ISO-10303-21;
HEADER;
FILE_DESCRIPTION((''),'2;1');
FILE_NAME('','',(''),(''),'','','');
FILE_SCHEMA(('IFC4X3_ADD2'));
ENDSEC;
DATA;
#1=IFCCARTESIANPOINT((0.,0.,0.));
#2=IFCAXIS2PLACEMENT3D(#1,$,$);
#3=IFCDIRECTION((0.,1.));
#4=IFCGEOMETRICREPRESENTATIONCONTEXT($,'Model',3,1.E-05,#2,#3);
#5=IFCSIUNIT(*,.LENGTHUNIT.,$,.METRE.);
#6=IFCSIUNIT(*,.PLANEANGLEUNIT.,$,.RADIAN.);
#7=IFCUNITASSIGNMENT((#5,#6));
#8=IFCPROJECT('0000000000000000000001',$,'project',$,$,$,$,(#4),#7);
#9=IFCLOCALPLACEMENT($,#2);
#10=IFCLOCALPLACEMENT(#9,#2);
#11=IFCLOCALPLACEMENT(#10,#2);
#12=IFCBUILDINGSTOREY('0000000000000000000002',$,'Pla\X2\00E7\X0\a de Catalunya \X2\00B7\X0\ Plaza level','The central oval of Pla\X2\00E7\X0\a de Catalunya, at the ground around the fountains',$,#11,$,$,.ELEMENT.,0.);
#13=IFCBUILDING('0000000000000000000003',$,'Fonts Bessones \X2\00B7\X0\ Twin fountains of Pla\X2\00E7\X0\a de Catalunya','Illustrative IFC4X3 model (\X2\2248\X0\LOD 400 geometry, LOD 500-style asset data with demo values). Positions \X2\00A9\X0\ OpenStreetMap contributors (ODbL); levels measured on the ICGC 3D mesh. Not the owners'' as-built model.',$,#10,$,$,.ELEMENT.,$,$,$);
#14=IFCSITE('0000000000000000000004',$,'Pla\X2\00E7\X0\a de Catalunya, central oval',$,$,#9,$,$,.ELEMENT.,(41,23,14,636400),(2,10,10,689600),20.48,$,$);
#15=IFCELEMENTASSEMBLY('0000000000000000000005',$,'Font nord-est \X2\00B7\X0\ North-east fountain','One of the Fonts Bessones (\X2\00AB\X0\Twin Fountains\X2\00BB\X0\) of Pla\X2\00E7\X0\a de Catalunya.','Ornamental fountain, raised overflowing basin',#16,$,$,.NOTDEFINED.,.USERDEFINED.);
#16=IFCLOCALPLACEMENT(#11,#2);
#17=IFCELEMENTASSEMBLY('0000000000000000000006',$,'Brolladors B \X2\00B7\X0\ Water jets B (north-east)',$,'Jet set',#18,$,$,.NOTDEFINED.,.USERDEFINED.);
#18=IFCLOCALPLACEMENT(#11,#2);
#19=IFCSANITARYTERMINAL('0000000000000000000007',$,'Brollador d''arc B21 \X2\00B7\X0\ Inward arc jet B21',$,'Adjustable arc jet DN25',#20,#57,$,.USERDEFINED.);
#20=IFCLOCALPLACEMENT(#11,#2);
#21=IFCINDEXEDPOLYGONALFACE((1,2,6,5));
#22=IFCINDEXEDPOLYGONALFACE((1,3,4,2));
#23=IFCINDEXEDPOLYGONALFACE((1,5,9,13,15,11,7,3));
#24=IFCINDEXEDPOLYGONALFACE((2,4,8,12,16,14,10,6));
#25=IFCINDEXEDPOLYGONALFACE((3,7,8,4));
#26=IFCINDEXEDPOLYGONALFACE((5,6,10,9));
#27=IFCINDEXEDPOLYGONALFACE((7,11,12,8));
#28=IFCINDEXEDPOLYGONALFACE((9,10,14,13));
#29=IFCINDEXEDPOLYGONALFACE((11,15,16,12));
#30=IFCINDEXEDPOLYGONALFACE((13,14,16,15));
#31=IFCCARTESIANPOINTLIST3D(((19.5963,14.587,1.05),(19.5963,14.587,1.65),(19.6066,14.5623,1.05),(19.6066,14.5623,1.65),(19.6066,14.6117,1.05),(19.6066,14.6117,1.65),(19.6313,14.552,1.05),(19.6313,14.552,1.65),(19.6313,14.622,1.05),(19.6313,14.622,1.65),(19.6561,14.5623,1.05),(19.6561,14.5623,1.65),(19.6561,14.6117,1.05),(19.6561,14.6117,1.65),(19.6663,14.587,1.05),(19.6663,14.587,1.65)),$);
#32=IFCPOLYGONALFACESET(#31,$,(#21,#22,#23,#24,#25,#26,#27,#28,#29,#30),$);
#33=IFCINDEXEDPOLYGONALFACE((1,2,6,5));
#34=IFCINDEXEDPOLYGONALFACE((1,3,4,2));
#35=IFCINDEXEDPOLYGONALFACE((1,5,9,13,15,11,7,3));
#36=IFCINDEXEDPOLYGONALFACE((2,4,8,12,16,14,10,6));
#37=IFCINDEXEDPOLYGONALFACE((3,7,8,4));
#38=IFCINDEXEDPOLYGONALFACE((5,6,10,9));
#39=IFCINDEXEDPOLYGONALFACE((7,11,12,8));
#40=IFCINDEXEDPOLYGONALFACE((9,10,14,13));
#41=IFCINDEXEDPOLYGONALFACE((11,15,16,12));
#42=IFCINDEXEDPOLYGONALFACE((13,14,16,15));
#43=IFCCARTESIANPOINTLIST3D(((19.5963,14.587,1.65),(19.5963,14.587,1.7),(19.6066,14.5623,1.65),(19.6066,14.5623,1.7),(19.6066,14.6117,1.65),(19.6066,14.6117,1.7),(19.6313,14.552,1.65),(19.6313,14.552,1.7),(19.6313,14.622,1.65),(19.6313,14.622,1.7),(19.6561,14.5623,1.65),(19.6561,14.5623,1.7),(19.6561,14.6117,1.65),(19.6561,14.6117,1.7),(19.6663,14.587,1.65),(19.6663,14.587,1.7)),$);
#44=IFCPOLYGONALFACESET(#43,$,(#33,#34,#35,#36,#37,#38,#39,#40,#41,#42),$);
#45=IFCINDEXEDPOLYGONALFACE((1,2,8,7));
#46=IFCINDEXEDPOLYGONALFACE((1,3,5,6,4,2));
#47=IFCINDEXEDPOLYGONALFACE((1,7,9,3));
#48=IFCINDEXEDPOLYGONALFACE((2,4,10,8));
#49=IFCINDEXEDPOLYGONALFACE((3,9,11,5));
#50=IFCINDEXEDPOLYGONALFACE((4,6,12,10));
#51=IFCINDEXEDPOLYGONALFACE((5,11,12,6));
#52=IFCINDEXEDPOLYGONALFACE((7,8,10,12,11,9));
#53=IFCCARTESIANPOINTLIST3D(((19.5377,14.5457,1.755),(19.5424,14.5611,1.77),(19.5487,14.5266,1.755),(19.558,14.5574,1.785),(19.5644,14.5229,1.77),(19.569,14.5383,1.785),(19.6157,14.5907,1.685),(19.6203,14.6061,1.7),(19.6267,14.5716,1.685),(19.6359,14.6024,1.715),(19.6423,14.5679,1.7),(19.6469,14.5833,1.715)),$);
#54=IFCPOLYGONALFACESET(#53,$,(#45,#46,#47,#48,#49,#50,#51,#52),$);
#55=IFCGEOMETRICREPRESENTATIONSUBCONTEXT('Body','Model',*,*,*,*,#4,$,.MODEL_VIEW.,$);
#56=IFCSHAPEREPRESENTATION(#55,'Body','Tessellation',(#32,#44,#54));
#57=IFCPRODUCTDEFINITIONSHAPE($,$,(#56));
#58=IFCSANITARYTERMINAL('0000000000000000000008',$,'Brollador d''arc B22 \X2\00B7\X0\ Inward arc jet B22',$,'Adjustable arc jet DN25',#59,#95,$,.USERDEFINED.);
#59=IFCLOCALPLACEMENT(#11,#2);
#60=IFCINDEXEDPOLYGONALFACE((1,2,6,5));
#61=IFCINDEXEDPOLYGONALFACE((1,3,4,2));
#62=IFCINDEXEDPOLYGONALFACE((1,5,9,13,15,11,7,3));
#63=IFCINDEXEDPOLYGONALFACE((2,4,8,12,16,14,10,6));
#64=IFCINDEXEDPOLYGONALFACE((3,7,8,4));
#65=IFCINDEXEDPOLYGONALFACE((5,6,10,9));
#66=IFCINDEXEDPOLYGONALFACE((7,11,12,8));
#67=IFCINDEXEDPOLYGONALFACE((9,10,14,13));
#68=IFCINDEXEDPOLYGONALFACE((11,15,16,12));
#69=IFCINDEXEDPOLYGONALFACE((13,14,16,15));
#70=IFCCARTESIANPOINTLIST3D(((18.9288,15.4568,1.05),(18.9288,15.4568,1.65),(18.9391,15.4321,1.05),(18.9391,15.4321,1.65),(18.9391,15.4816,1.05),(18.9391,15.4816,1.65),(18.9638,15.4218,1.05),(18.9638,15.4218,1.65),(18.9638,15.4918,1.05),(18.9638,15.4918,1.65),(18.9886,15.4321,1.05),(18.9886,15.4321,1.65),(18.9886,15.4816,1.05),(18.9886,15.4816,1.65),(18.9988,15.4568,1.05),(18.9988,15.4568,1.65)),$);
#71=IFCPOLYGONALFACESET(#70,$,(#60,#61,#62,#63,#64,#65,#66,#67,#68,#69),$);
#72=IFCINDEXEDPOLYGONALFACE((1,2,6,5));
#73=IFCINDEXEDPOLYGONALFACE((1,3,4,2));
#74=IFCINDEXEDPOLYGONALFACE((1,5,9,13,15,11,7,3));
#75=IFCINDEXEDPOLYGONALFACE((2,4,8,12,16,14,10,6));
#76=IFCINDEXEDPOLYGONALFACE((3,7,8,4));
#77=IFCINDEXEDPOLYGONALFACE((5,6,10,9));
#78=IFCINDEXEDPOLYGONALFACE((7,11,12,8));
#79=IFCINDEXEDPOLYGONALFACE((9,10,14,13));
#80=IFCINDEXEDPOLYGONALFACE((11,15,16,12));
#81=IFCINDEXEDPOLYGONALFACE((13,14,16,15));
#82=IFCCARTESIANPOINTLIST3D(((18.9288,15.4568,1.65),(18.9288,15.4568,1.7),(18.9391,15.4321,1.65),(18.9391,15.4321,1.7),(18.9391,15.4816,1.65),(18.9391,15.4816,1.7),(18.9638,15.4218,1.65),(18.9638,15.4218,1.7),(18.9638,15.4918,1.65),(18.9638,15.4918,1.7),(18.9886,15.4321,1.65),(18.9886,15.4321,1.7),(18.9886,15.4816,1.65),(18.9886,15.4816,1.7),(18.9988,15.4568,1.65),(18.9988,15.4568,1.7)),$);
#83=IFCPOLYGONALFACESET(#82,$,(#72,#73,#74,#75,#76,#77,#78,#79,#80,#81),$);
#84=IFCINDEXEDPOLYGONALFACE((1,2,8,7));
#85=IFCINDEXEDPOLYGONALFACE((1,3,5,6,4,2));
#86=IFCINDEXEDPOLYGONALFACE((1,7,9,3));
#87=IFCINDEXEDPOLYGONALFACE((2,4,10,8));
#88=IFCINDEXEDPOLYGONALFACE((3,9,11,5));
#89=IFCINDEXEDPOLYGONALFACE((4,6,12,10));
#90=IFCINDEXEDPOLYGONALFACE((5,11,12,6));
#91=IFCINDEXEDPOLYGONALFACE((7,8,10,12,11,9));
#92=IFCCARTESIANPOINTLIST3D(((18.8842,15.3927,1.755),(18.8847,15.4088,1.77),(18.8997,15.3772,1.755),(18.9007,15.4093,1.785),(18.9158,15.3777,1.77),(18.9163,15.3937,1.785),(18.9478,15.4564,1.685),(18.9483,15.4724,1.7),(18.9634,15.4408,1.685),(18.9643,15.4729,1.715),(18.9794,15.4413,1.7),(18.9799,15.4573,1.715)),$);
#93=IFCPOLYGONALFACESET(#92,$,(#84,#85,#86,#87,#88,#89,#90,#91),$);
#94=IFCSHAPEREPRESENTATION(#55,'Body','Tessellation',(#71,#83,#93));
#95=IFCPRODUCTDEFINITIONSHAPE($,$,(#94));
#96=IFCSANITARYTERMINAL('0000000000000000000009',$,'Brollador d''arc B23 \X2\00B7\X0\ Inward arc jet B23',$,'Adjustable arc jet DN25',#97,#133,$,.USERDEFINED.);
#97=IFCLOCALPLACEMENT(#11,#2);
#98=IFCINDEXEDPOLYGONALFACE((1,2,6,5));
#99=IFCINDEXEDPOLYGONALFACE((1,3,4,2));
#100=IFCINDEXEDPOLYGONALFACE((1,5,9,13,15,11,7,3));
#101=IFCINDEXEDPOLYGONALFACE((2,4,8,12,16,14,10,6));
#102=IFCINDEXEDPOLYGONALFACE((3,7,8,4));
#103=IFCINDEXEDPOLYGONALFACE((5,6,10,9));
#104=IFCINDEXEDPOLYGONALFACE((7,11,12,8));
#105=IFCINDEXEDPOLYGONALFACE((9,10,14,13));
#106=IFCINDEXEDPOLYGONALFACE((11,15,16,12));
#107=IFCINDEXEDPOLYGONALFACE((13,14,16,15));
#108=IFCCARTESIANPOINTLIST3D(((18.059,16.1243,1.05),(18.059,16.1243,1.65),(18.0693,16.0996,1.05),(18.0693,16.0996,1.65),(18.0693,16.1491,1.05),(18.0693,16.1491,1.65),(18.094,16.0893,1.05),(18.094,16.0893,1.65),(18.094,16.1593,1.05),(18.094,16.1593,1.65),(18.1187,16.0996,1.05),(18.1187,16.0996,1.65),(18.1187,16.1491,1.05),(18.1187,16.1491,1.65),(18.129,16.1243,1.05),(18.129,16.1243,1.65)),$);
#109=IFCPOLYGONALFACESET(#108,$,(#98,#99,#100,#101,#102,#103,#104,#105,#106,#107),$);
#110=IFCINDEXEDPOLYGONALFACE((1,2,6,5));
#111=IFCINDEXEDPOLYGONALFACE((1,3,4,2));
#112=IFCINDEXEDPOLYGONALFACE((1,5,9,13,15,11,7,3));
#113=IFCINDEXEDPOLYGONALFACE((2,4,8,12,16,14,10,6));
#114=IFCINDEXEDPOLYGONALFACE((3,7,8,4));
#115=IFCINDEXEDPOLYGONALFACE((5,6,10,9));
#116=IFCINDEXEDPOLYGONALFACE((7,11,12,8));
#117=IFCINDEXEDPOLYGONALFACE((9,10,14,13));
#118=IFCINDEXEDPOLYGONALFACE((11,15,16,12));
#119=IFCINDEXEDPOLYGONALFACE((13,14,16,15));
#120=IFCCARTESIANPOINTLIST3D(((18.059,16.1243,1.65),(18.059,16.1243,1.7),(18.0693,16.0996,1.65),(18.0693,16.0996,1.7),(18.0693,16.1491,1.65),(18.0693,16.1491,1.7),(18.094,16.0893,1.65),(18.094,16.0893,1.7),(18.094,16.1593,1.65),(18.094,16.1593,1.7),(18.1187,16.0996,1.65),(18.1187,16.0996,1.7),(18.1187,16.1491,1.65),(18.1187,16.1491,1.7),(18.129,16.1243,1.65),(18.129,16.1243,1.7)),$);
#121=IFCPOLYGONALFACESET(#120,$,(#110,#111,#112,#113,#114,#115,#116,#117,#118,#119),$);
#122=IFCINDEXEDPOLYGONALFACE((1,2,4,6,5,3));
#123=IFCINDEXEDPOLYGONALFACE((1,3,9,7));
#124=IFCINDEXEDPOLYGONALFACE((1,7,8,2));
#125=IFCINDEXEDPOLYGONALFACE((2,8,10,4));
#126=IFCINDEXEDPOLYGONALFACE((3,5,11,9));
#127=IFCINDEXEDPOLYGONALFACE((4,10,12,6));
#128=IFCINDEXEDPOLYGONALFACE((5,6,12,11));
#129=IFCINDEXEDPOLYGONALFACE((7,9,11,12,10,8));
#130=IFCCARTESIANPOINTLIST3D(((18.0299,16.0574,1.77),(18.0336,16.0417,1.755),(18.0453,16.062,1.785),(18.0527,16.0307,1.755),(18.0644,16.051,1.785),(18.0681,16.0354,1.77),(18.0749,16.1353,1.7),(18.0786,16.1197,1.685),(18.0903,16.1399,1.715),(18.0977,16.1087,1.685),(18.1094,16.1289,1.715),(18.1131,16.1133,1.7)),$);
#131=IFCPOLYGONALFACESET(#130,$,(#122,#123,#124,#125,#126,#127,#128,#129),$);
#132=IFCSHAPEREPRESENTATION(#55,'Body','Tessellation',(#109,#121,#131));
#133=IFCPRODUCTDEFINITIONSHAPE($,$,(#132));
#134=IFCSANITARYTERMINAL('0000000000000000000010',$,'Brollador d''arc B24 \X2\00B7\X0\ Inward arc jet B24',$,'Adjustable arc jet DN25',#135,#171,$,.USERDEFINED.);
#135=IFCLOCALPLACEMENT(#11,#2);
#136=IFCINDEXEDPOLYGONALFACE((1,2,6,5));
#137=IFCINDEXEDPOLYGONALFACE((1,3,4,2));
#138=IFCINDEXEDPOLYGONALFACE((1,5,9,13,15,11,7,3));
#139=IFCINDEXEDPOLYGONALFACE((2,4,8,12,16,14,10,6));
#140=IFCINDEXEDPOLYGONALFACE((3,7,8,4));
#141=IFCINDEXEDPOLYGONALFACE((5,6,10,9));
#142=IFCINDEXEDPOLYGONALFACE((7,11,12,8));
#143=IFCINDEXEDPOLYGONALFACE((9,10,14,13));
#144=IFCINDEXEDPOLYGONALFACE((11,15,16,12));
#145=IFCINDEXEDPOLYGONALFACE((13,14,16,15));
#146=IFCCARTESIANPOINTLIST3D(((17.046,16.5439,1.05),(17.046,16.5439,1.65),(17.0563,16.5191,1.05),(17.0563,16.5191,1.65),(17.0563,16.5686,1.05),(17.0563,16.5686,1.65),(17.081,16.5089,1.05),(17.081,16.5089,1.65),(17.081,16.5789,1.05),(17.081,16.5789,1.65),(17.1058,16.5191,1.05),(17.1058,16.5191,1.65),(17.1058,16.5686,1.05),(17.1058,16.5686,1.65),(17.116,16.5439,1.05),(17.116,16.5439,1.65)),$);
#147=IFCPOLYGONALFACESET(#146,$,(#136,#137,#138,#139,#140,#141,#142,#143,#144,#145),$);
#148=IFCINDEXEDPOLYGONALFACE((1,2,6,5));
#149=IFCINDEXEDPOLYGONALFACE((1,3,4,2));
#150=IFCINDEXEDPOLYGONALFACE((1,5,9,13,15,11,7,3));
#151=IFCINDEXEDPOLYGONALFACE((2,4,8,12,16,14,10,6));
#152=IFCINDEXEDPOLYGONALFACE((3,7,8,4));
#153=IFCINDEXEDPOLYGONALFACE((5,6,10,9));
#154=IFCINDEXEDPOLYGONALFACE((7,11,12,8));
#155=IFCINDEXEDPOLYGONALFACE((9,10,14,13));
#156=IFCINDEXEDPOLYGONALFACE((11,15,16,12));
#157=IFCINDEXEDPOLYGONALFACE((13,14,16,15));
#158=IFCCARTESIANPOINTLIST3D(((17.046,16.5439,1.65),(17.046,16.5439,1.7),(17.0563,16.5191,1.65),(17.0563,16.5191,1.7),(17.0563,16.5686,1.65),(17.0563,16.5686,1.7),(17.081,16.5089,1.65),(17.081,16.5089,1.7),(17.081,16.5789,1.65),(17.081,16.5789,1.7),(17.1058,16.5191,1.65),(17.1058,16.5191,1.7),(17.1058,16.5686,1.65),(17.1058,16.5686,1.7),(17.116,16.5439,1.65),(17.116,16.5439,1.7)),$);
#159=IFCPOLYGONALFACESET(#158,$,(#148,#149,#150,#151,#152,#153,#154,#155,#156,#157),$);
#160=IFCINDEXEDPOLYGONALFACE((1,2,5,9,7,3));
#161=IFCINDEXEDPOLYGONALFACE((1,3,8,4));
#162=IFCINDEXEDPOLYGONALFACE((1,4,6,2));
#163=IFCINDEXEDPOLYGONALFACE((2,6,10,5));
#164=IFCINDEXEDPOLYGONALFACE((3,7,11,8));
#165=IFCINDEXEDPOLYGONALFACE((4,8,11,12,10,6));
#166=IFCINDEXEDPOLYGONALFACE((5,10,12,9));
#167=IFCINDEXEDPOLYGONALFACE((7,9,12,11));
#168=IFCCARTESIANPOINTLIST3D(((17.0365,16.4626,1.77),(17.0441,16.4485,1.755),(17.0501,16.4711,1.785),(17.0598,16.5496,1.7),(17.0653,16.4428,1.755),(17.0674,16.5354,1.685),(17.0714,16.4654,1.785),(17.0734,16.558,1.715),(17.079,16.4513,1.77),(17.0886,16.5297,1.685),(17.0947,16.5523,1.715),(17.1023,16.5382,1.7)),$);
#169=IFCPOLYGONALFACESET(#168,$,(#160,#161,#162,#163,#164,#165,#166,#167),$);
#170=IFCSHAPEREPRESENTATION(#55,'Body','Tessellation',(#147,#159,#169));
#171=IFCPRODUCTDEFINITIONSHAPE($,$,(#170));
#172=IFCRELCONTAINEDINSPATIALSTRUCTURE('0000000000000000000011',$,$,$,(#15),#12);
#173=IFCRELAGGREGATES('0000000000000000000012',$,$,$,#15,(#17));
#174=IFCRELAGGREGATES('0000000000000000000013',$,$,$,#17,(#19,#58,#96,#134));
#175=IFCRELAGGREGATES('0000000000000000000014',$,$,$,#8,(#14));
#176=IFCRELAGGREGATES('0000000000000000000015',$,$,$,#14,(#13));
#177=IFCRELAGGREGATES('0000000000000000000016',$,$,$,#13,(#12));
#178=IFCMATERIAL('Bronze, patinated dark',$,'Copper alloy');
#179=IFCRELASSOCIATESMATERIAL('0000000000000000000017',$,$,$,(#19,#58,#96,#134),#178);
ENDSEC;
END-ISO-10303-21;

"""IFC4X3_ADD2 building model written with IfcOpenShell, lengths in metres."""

from ifc_helpers import new_model, si_unit, direction, frame, origin, place, context, subcontext, project, spatial, polyline, outline, extrude, material, element, aggregate, save


model = new_model("IFC4X3_ADD2")

# Units and contexts
model_context = context("Model", 3, precision=1e-05, world=origin(), true_north=direction((0.0, 1.0)))
body_context = subcontext(model_context, "Body", "Model", "MODEL_VIEW")
ifc_project = project(units=[si_unit("LENGTHUNIT", "METRE"), si_unit("PLANEANGLEUNIT", "RADIAN")], contexts=[model_context])

# Site, building, storey
site_placement = place(None, origin())
site = spatial("IfcSite", under=ifc_project, at=site_placement, Name="Plaça de Catalunya, central oval", CompositionType="ELEMENT", RefLatitude=(41, 23, 14, 636400), RefLongitude=(2, 10, 10, 689600), RefElevation=20.48)
building_placement = place(site_placement, origin())
building = spatial("IfcBuilding", under=site, at=building_placement, Name="Fonts Bessones · Twin fountains of Plaça de Catalunya", Description="Illustrative IFC4X3 model (≈LOD 400 geometry, LOD 500-style asset data with demo values). Positions © OpenStreetMap contributors (ODbL); levels measured on the ICGC 3D mesh. Not the owners' as-built model.", CompositionType="ELEMENT")
storey_placement = place(building_placement, origin())
storey = spatial("IfcBuildingStorey", under=building, at=storey_placement, Name="Plaça de Catalunya · Plaza level", Description="The central oval of Plaça de Catalunya, at the ground around the fountains", CompositionType="ELEMENT", Elevation=0.0)

# Element assemblies, sanitary terminals
assembly_1_placement = place(building_placement, origin())
assembly_1 = element("IfcElementAssembly", 1, at=assembly_1_placement, inside=storey, Name="Font nord-est · North-east fountain", Description="One of the Fonts Bessones («Twin Fountains») of Plaça de Catalunya.", ObjectType="Ornamental fountain, raised overflowing basin", AssemblyPlace="NOTDEFINED", PredefinedType="USERDEFINED")
assembly_2_placement = place(building_placement, origin())
assembly_2 = element("IfcElementAssembly", 2, at=assembly_2_placement, Name="Brolladors B · Water jets B (north-east)", ObjectType="Jet set", AssemblyPlace="NOTDEFINED", PredefinedType="USERDEFINED")
aggregate(assembly_1, [assembly_2])
ifc_material_1 = material(Name="Bronze, patinated dark", Category="Copper alloy")
sanitary_terminal_1_placement = place(building_placement, origin())
sanitary_terminal_1 = element("IfcSanitaryTerminal", 3, at=sanitary_terminal_1_placement, material=ifc_material_1, Name="Brollador d'arc B21 · Inward arc jet B21", ObjectType="Adjustable arc jet DN25", PredefinedType="USERDEFINED", context=body_context, shape_type="SweptSolid", body=[
    extrude(outline(polyline([(19.6663, 14.587), (19.6561, 14.6117), (19.6313, 14.622), (19.6066, 14.6117), (19.5963, 14.587), (19.6066, 14.5623), (19.6313, 14.552), (19.6561, 14.5623), (19.6663, 14.587)])), frame((0.0, 0.0, 1.05)), (0.0, 0.0, 1.0), 0.6),
    extrude(outline(polyline([(19.6663, 14.587), (19.6561, 14.6117), (19.6313, 14.622), (19.6066, 14.6117), (19.5963, 14.587), (19.6066, 14.5623), (19.6313, 14.552), (19.6561, 14.5623), (19.6663, 14.587)])), frame((0.0, 0.0, 1.65)), (0.0, 0.0, 1.0), 0.05),
    extrude(outline(polyline([(0.022, 0.0), (0.011, 0.0191), (-0.011, 0.0191), (-0.022, 0.0), (-0.011, -0.0191), (0.011, -0.0191), (0.022, 0.0)])), frame((19.6313, 14.587, 1.7), z_axis=(-0.683599, -0.394676, 0.613941), x_axis=(-0.5, 0.866025, 0.0)), (0.0, 0.0, 1.0), 0.114),
])
sanitary_terminal_2_placement = place(building_placement, origin())
sanitary_terminal_2 = element("IfcSanitaryTerminal", 4, at=sanitary_terminal_2_placement, material=ifc_material_1, Name="Brollador d'arc B22 · Inward arc jet B22", ObjectType="Adjustable arc jet DN25", PredefinedType="USERDEFINED", context=body_context, shape_type="SweptSolid", body=[
    extrude(outline(polyline([(18.9988, 15.4568), (18.9886, 15.4816), (18.9638, 15.4918), (18.9391, 15.4816), (18.9288, 15.4568), (18.9391, 15.4321), (18.9638, 15.4218), (18.9886, 15.4321), (18.9988, 15.4568)])), frame((0.0, 0.0, 1.05)), (0.0, 0.0, 1.0), 0.6),
    extrude(outline(polyline([(18.9988, 15.4568), (18.9886, 15.4816), (18.9638, 15.4918), (18.9391, 15.4816), (18.9288, 15.4568), (18.9391, 15.4321), (18.9638, 15.4218), (18.9886, 15.4321), (18.9988, 15.4568)])), frame((0.0, 0.0, 1.65)), (0.0, 0.0, 1.0), 0.05),
    extrude(outline(polyline([(0.022, 0.0), (0.011, 0.0191), (-0.011, 0.0191), (-0.022, 0.0), (-0.011, -0.0191), (0.011, -0.0191), (0.022, 0.0)])), frame((18.9638, 15.4568, 1.7), z_axis=(-0.558156, -0.558156, 0.613941), x_axis=(-0.707107, 0.707107, 0.0)), (0.0, 0.0, 1.0), 0.114),
])
sanitary_terminal_3_placement = place(building_placement, origin())
sanitary_terminal_3 = element("IfcSanitaryTerminal", 5, at=sanitary_terminal_3_placement, material=ifc_material_1, Name="Brollador d'arc B23 · Inward arc jet B23", ObjectType="Adjustable arc jet DN25", PredefinedType="USERDEFINED", context=body_context, shape_type="SweptSolid", body=[
    extrude(outline(polyline([(18.129, 16.1243), (18.1187, 16.1491), (18.094, 16.1593), (18.0693, 16.1491), (18.059, 16.1243), (18.0693, 16.0996), (18.094, 16.0893), (18.1187, 16.0996), (18.129, 16.1243)])), frame((0.0, 0.0, 1.05)), (0.0, 0.0, 1.0), 0.6),
    extrude(outline(polyline([(18.129, 16.1243), (18.1187, 16.1491), (18.094, 16.1593), (18.0693, 16.1491), (18.059, 16.1243), (18.0693, 16.0996), (18.094, 16.0893), (18.1187, 16.0996), (18.129, 16.1243)])), frame((0.0, 0.0, 1.65)), (0.0, 0.0, 1.0), 0.05),
    extrude(outline(polyline([(0.022, 0.0), (0.011, 0.0191), (-0.011, 0.0191), (-0.022, 0.0), (-0.011, -0.0191), (0.011, -0.0191), (0.022, 0.0)])), frame((18.094, 16.1243, 1.7), z_axis=(-0.394676, -0.683599, 0.613941), x_axis=(-0.866025, 0.5, 0.0)), (0.0, 0.0, 1.0), 0.114),
])
sanitary_terminal_4_placement = place(building_placement, origin())
sanitary_terminal_4 = element("IfcSanitaryTerminal", 6, at=sanitary_terminal_4_placement, material=ifc_material_1, Name="Brollador d'arc B24 · Inward arc jet B24", ObjectType="Adjustable arc jet DN25", PredefinedType="USERDEFINED", context=body_context, shape_type="SweptSolid", body=[
    extrude(outline(polyline([(17.116, 16.5439), (17.1058, 16.5686), (17.081, 16.5789), (17.0563, 16.5686), (17.046, 16.5439), (17.0563, 16.5191), (17.081, 16.5089), (17.1058, 16.5191), (17.116, 16.5439)])), frame((0.0, 0.0, 1.05)), (0.0, 0.0, 1.0), 0.6),
    extrude(outline(polyline([(17.116, 16.5439), (17.1058, 16.5686), (17.081, 16.5789), (17.0563, 16.5686), (17.046, 16.5439), (17.0563, 16.5191), (17.081, 16.5089), (17.1058, 16.5191), (17.116, 16.5439)])), frame((0.0, 0.0, 1.65)), (0.0, 0.0, 1.0), 0.05),
    extrude(outline(polyline([(0.022, 0.0), (0.011, 0.0191), (-0.011, 0.0191), (-0.022, 0.0), (-0.011, -0.0191), (0.011, -0.0191), (0.022, 0.0)])), frame((17.081, 16.5439, 1.7), z_axis=(-0.204299, -0.762456, 0.613941), x_axis=(-0.965926, 0.258819, 0.0)), (0.0, 0.0, 1.0), 0.114),
])
aggregate(assembly_2, [sanitary_terminal_1, sanitary_terminal_2, sanitary_terminal_3, sanitary_terminal_4])

save(model, "model.ifc")
